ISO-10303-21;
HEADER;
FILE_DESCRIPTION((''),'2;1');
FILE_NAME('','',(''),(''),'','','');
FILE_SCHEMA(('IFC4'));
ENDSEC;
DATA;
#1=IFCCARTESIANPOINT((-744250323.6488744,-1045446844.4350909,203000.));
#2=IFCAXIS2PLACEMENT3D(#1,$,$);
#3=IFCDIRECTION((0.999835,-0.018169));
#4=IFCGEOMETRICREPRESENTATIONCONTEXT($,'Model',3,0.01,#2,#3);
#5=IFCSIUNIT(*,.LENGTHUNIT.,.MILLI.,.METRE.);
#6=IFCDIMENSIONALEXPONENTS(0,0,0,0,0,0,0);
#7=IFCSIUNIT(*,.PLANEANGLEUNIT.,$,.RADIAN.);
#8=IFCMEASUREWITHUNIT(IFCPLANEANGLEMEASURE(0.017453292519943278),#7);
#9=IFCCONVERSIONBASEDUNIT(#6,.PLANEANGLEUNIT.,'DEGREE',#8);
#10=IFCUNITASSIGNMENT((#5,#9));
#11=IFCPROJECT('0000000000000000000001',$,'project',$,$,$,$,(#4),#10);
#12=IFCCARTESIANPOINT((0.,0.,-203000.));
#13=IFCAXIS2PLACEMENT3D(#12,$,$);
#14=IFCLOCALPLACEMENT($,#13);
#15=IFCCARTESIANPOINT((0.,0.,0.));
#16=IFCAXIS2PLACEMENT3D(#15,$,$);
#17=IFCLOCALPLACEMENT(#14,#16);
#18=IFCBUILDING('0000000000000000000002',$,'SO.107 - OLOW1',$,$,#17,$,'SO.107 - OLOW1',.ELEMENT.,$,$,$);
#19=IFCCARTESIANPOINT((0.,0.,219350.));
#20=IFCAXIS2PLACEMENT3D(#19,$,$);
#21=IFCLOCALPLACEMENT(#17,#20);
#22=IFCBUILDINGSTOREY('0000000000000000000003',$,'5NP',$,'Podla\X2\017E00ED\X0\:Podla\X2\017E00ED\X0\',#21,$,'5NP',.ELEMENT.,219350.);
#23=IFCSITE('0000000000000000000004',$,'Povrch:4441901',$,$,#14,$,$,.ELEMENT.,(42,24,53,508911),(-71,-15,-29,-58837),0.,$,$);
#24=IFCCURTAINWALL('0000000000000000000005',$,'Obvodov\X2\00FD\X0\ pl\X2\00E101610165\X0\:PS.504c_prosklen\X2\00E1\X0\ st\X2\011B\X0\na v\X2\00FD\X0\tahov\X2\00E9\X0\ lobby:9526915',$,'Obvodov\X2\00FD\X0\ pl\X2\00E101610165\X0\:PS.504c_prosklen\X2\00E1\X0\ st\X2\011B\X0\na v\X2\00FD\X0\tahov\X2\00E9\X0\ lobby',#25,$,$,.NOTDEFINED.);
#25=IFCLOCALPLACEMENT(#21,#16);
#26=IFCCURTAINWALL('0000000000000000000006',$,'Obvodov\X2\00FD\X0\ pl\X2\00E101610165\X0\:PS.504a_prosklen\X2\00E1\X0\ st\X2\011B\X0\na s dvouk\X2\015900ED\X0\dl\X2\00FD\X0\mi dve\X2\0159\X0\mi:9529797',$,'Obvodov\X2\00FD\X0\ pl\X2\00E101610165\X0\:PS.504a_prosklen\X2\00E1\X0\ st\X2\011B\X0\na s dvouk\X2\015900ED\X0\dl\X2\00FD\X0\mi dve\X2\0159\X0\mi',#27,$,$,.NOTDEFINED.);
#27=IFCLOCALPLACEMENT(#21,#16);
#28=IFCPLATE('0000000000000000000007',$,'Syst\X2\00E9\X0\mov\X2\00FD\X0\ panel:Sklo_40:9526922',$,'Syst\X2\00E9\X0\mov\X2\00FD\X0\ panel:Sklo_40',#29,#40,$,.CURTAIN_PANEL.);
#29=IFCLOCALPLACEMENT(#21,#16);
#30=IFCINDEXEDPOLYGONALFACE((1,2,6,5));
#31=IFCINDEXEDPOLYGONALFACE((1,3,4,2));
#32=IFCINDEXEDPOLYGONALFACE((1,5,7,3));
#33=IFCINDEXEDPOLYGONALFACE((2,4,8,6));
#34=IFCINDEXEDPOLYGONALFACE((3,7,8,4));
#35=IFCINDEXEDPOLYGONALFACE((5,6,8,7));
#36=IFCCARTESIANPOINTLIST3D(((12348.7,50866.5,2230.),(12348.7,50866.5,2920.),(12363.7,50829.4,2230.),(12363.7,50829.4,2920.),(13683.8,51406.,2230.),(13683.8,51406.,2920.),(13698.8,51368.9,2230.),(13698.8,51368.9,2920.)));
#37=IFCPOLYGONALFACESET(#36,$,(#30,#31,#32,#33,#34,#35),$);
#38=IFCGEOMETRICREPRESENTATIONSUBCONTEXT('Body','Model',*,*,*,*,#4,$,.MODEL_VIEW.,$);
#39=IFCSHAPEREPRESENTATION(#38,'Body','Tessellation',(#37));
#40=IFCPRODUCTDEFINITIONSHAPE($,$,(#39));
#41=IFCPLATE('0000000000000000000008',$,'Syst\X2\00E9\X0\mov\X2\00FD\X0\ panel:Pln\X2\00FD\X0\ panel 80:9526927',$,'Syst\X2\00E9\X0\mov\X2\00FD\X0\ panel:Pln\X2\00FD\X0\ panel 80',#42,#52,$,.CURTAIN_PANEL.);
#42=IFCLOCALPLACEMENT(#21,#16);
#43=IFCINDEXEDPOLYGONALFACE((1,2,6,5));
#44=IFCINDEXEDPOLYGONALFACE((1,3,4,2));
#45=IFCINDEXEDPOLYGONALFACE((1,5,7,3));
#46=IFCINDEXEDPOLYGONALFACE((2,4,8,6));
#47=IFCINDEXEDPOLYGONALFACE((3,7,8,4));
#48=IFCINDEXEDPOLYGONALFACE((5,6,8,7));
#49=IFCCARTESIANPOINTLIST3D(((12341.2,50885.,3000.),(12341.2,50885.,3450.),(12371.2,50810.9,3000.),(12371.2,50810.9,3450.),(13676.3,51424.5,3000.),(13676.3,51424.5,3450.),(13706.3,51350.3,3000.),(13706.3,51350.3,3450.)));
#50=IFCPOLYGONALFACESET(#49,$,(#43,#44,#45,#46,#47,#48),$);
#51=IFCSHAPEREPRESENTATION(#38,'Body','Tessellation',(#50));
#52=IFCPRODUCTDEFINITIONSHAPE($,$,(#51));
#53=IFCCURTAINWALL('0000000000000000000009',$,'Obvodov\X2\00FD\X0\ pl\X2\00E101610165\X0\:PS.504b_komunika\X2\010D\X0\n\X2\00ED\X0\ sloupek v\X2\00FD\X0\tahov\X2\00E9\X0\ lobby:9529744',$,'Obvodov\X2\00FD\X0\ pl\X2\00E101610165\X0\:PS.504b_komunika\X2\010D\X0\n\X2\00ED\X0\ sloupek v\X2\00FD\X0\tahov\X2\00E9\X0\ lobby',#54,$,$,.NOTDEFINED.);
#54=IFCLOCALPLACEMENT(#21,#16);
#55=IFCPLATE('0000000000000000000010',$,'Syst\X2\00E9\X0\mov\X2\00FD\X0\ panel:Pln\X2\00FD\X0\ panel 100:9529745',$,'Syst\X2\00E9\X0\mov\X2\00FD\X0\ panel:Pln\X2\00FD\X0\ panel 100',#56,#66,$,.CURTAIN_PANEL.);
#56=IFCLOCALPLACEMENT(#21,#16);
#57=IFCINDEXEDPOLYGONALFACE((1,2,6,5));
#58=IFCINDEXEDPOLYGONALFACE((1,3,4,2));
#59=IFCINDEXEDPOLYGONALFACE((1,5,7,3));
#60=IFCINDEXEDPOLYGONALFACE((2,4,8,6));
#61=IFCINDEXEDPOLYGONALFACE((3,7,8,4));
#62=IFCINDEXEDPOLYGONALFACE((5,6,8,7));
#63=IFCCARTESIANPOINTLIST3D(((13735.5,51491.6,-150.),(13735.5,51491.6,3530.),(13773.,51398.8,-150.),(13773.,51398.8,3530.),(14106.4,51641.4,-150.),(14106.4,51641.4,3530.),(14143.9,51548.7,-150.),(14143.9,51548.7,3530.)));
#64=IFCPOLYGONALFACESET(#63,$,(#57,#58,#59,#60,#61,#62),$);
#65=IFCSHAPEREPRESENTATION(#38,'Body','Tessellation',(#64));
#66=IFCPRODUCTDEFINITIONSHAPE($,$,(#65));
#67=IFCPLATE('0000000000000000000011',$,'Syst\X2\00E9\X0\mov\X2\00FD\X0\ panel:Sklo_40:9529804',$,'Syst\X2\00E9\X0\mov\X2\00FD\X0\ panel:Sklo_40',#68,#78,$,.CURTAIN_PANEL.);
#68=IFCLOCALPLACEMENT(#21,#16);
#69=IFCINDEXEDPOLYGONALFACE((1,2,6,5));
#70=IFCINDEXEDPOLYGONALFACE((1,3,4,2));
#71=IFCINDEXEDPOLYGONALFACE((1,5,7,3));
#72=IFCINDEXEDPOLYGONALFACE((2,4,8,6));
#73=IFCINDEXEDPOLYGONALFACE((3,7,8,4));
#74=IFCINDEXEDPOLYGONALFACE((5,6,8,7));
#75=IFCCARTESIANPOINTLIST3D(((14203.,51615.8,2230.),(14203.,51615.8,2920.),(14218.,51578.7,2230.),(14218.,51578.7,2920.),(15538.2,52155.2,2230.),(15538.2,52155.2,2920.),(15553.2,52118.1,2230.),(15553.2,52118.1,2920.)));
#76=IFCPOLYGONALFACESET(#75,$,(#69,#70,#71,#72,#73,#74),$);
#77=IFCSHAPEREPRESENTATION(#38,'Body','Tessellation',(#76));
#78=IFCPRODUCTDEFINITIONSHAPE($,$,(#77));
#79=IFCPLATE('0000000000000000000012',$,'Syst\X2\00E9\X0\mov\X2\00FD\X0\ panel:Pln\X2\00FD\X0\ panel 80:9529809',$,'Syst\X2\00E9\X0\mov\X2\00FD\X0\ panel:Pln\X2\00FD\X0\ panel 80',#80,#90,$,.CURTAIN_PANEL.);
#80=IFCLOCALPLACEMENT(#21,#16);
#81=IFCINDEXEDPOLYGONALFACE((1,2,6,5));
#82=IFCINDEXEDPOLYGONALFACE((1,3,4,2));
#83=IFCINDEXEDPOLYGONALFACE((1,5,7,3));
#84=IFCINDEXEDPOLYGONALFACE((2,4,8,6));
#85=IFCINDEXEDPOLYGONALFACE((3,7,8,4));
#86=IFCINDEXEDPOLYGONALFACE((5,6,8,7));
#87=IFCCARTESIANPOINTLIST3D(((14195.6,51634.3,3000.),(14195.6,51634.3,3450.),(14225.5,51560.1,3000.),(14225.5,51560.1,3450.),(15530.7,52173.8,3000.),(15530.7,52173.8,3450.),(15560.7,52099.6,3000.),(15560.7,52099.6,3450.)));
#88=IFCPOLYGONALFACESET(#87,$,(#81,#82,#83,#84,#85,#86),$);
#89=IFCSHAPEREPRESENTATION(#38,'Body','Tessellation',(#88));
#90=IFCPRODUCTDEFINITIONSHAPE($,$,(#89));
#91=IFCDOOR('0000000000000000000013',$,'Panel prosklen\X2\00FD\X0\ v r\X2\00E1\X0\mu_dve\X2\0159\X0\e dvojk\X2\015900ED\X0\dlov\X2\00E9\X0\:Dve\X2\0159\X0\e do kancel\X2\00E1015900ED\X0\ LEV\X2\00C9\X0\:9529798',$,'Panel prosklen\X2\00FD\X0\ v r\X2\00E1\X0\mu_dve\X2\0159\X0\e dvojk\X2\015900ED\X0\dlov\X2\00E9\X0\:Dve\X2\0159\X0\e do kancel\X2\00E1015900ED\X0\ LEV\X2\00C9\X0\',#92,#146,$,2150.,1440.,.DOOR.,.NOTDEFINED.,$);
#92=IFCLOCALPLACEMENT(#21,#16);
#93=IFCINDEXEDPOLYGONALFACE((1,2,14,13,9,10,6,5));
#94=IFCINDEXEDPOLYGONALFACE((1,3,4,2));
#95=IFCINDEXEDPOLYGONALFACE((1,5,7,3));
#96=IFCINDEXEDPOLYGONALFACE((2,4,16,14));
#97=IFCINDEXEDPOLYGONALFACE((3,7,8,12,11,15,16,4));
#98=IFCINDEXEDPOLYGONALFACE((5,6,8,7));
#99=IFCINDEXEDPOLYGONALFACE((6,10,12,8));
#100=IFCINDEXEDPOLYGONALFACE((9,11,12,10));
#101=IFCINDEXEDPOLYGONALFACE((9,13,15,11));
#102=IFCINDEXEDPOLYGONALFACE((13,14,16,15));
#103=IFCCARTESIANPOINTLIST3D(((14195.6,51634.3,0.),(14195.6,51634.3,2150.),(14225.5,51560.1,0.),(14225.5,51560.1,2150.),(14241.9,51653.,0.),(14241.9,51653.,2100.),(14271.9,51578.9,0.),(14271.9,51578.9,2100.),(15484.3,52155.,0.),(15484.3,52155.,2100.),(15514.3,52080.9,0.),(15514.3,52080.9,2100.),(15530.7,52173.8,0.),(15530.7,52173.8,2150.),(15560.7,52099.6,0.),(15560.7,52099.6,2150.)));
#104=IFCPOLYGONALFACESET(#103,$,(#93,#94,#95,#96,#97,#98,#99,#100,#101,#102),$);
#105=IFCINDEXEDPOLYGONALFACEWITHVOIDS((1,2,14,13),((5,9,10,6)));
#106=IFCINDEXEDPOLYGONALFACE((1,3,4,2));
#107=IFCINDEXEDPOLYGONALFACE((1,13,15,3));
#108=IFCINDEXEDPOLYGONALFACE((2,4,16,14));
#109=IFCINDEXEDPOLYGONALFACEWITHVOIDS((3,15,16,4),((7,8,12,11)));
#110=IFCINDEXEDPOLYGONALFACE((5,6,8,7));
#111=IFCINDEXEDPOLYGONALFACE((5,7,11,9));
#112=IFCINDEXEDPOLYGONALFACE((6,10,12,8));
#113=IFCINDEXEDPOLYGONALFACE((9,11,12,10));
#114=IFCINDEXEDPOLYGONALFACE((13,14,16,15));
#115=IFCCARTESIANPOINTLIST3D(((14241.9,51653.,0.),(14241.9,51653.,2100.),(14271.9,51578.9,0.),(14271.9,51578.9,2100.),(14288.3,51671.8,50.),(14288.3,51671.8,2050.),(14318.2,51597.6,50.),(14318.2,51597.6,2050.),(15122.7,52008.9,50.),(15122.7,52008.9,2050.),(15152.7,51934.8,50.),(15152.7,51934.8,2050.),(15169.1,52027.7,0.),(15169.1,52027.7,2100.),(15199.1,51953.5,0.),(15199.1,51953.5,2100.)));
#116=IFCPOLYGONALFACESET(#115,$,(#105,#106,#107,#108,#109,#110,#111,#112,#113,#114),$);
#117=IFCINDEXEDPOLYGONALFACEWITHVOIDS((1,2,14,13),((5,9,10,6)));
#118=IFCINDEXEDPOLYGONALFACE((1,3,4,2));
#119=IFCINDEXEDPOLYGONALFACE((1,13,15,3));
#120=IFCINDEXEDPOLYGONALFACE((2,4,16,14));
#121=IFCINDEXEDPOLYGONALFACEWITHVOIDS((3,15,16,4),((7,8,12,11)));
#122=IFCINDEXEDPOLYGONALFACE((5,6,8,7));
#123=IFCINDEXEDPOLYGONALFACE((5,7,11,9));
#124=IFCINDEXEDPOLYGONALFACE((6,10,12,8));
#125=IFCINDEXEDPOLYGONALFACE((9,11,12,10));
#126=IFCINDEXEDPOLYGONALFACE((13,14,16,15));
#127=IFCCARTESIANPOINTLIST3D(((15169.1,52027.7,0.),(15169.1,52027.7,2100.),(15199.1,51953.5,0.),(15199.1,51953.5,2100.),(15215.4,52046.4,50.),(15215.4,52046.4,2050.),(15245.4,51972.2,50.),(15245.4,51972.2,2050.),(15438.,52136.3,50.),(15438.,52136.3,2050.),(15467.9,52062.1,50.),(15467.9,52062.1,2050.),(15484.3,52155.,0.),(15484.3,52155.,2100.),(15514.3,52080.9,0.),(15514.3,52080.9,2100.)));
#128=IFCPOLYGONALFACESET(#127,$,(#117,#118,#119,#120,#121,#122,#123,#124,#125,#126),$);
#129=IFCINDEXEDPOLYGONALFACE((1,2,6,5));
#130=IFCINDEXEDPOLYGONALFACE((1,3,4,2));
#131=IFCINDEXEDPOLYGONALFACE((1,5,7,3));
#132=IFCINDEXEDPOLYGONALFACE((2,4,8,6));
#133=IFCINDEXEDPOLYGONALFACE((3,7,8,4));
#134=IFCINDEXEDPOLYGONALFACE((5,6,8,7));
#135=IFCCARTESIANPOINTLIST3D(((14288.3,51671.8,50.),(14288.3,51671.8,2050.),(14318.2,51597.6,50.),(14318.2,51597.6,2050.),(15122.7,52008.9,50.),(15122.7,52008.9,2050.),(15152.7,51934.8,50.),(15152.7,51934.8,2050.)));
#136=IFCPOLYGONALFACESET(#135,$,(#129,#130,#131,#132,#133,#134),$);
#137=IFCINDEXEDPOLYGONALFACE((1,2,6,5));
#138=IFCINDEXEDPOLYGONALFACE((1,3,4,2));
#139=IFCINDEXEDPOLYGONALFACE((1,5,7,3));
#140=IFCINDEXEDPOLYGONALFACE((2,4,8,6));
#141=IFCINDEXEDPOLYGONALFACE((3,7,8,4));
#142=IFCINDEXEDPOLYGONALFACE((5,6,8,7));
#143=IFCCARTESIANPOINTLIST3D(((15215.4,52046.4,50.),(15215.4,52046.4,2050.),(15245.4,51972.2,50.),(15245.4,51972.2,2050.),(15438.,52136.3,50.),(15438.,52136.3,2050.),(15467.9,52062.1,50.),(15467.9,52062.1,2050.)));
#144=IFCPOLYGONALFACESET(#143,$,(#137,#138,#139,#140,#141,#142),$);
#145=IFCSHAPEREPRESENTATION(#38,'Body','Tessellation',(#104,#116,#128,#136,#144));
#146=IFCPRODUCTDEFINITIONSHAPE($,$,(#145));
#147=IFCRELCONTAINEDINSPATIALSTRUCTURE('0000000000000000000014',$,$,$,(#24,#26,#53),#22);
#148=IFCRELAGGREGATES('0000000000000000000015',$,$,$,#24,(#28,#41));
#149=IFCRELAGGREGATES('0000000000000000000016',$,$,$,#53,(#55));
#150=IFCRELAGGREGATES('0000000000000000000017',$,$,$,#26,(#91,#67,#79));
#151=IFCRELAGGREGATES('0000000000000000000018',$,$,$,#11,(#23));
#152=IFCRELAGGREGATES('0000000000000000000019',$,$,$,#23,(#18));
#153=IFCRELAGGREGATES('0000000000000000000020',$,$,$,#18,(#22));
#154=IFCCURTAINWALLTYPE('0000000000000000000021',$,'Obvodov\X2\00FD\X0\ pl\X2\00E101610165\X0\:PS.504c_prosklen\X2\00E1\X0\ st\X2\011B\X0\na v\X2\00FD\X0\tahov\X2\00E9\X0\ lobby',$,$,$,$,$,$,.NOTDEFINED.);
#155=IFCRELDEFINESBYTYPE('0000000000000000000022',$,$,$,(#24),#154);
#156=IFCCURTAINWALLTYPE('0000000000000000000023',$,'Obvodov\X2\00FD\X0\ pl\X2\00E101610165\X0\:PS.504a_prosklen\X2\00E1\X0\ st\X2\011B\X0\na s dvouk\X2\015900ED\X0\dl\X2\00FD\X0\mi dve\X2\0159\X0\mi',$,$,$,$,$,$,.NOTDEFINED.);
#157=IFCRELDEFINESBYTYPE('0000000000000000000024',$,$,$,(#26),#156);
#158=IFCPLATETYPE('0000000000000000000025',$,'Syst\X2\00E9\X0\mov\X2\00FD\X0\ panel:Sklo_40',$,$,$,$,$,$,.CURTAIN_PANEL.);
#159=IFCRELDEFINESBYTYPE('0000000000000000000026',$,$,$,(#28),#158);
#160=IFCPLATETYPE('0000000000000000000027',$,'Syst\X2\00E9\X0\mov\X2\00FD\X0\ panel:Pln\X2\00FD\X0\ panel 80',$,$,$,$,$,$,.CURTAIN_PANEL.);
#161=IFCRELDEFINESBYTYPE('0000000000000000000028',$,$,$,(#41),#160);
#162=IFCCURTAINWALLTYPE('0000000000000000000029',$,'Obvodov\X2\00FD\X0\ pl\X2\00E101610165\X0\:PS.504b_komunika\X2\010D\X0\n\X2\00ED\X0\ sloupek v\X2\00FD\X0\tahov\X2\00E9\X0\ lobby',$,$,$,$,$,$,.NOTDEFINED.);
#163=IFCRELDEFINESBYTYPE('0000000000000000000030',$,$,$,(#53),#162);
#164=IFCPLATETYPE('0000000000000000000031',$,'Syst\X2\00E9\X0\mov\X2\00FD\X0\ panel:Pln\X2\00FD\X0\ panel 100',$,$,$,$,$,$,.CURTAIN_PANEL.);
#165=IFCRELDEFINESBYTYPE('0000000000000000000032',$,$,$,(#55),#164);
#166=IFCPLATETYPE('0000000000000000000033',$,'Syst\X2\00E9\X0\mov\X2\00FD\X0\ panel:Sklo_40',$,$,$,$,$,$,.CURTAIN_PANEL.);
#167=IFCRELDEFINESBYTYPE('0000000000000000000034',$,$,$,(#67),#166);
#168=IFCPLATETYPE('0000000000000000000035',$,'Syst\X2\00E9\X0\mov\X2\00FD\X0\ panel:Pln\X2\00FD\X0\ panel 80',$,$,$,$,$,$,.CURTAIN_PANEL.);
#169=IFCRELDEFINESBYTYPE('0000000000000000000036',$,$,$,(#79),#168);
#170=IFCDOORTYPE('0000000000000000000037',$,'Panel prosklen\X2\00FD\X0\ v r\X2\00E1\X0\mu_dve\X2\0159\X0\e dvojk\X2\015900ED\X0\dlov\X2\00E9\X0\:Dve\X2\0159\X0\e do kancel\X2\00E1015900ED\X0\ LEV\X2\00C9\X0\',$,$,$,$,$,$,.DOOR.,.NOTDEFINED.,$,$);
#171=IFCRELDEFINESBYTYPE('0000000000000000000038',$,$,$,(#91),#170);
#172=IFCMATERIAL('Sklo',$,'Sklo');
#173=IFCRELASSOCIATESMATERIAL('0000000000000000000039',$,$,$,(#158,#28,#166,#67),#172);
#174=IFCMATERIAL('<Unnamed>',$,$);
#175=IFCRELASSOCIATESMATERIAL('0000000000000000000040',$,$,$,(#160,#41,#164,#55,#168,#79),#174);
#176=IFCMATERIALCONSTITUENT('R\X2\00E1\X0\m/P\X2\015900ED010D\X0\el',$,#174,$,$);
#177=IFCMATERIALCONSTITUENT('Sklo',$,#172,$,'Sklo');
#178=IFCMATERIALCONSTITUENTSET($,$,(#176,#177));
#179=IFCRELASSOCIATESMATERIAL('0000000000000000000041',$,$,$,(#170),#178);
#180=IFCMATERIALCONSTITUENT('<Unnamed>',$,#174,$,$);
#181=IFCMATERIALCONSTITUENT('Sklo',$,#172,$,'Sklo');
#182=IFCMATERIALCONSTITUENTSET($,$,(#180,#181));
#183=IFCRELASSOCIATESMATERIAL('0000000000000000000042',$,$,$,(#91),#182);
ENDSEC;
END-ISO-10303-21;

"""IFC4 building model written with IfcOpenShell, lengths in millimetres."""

from ifc_helpers import new_model, entity, si_unit, converted_unit, direction, frame, origin, place, context, subcontext, project, spatial, indexed_curve, outline, extrude, source, transform, mapped, material, constituent, constituent_set, type_object, type_shapes, element, aggregate, save


model = new_model("IFC4")

# Units and contexts
model_context = context("Model", 3, precision=0.01, world=frame((-744250323.6488744, -1045446844.4350909, 203000.0)), true_north=direction((0.999835, -0.018169)))
body_context = subcontext(model_context, "Body", "Model", "MODEL_VIEW")
ifc_project = project(units=[si_unit("LENGTHUNIT", "METRE", prefix="MILLI"), converted_unit("PLANEANGLEUNIT", "DEGREE", entity("IfcPlaneAngleMeasure", 0.017453292519943278), si_unit("PLANEANGLEUNIT", "RADIAN"), dimensions=[0, 0, 0, 0, 0, 0, 0])], contexts=[model_context])

# Site, building, storey
site_placement = place(None, frame((0.0, 0.0, -203000.0)))
site = spatial("IfcSite", under=ifc_project, at=site_placement, Name="Povrch:4441901", CompositionType="ELEMENT", RefLatitude=(42, 24, 53, 508911), RefLongitude=(-71, -15, -29, -58837), RefElevation=0.0)
building_placement = place(site_placement, origin())
building = spatial("IfcBuilding", under=site, at=building_placement, Name="SO.107 - OLOW1", LongName="SO.107 - OLOW1", CompositionType="ELEMENT")
storey_placement = place(building_placement, frame((0.0, 0.0, 219350.0)))
storey = spatial("IfcBuildingStorey", under=building, at=storey_placement, Name="5NP", ObjectType="Podlaží:Podlaží", LongName="5NP", CompositionType="ELEMENT", Elevation=219350.0)

# Curtain walls
curtain_wall_type_1 = type_object("IfcCurtainWallType", Name="Obvodový plášť:PS.504c_prosklená stěna výtahové lobby", PredefinedType="NOTDEFINED")
curtain_wall_1_placement = place(storey_placement, frame((0.0, 0.0, -219350.0)))
curtain_wall_1 = element("IfcCurtainWall", 1, at=curtain_wall_1_placement, inside=storey, type_object=curtain_wall_type_1, Name="Obvodový plášť:PS.504c_prosklená stěna výtahové lobby:9526915", ObjectType="Obvodový plášť:PS.504c_prosklená stěna výtahové lobby", PredefinedType="NOTDEFINED")
ifc_material_1 = material(Name="<Unnamed>")
curtain_wall_type_2 = type_object("IfcCurtainWallType", Name="Obvodový plášť:PS.504a_prosklená stěna s dvoukřídlými dveřmi", PredefinedType="NOTDEFINED")
curtain_wall_2_placement = place(storey_placement, frame((0.0, 0.0, -219350.0)))
curtain_wall_2 = element("IfcCurtainWall", 2, at=curtain_wall_2_placement, inside=storey, type_object=curtain_wall_type_2, Name="Obvodový plášť:PS.504a_prosklená stěna s dvoukřídlými dveřmi:9529797", ObjectType="Obvodový plášť:PS.504a_prosklená stěna s dvoukřídlými dveřmi", PredefinedType="NOTDEFINED")

# Plates
ifc_material_2 = material(Name="Sklo", Category="Sklo")
plate_type_1 = type_object("IfcPlateType", Name="Systémový panel:Sklo_40", PredefinedType="CURTAIN_PANEL", material=ifc_material_2)
shared_shape_1 = source(origin(), body_context, "Body", "SweptSolid", [
    extrude(outline(indexed_curve([(-20.0, -720.0), (20.0, -720.0), (20.0, 720.0), (-20.0, 720.0), (-20.0, -720.0)], self_intersect=False)), frame((0.0, 0.0, 0.0), z_axis=(0.0, 0.0, 1.0), x_axis=(0.0, 1.0, 0.0)), (0.0, 0.0, 1.0), 690.0),
])
type_shapes(plate_type_1, [shared_shape_1])
plate_1_placement = place(curtain_wall_1_placement, frame((13023.8, 51117.7, 221580.0), z_axis=(0.0, 0.0, 1.0), x_axis=(0.927176, 0.374626, 0.0)))
plate_1 = element("IfcPlate", 3, at=plate_1_placement, type_object=plate_type_1, material=ifc_material_2, Name="Systémový panel:Sklo_40:9526922", ObjectType="Systémový panel:Sklo_40", PredefinedType="CURTAIN_PANEL", context=body_context, shape_type="MappedRepresentation", body=[
    mapped(shared_shape_1, transform((0.0, 0.0, 0.0), scale=1.0)),
])
plate_type_2 = type_object("IfcPlateType", Name="Systémový panel:Plný panel 80", PredefinedType="CURTAIN_PANEL", material=ifc_material_1)
shared_shape_2 = source(origin(), body_context, "Body", "SweptSolid", [
    extrude(outline(indexed_curve([(-40.0, -720.0), (40.0, -720.0), (40.0, 720.0), (-40.0, 720.0), (-40.0, -720.0)], self_intersect=False)), frame((0.0, 0.0, 0.0), z_axis=(0.0, 0.0, 1.0), x_axis=(0.0, 1.0, 0.0)), (0.0, 0.0, 1.0), 450.0),
])
type_shapes(plate_type_2, [shared_shape_2])
plate_2_placement = place(curtain_wall_1_placement, frame((13023.8, 51117.7, 222350.0), z_axis=(0.0, 0.0, 1.0), x_axis=(0.927176, 0.374626, 0.0)))
plate_2 = element("IfcPlate", 4, at=plate_2_placement, type_object=plate_type_2, material=ifc_material_1, Name="Systémový panel:Plný panel 80:9526927", ObjectType="Systémový panel:Plný panel 80", PredefinedType="CURTAIN_PANEL", context=body_context, shape_type="MappedRepresentation", body=[
    mapped(shared_shape_2, transform((0.0, 0.0, 0.0), scale=1.0)),
])
aggregate(curtain_wall_1, [plate_1, plate_2])

# Curtain wall, plate
curtain_wall_type_3 = type_object("IfcCurtainWallType", Name="Obvodový plášť:PS.504b_komunikační sloupek výtahové lobby", PredefinedType="NOTDEFINED")
curtain_wall_3_placement = place(storey_placement, frame((0.0, 0.0, -219350.0)))
curtain_wall_3 = element("IfcCurtainWall", 5, at=curtain_wall_3_placement, inside=storey, type_object=curtain_wall_type_3, Name="Obvodový plášť:PS.504b_komunikační sloupek výtahové lobby:9529744", ObjectType="Obvodový plášť:PS.504b_komunikační sloupek výtahové lobby", PredefinedType="NOTDEFINED")
plate_type_3 = type_object("IfcPlateType", Name="Systémový panel:Plný panel 100", PredefinedType="CURTAIN_PANEL", material=ifc_material_1)
shared_shape_3 = source(origin(), body_context, "Body", "SweptSolid", [
    extrude(outline(indexed_curve([(-50.0, -200.0), (50.0, -200.0), (50.0, 200.0), (-50.0, 200.0), (-50.0, -200.0)], self_intersect=False)), frame((0.0, 50.0, 0.0), z_axis=(0.0, 0.0, 1.0), x_axis=(0.0, 1.0, 0.0)), (0.0, 0.0, 1.0), 3680.0),
])
type_shapes(plate_type_3, [shared_shape_3])
plate_3_placement = place(curtain_wall_3_placement, frame((13958.4, 51473.8, 219200.0), z_axis=(0.0, 0.0, 1.0), x_axis=(0.927176, 0.374626, 0.0)))
plate_3 = element("IfcPlate", 6, at=plate_3_placement, type_object=plate_type_3, material=ifc_material_1, Name="Systémový panel:Plný panel 100:9529745", ObjectType="Systémový panel:Plný panel 100", PredefinedType="CURTAIN_PANEL", context=body_context, shape_type="MappedRepresentation", body=[
    mapped(shared_shape_3, transform((0.0, 0.0, 0.0), scale=1.0)),
])
aggregate(curtain_wall_3, [plate_3])

# Plates
plate_type_4 = type_object("IfcPlateType", Name="Systémový panel:Sklo_40", PredefinedType="CURTAIN_PANEL", material=ifc_material_2)
shared_shape_4 = source(origin(), body_context, "Body", "SweptSolid", [
    extrude(outline(indexed_curve([(-20.0, -720.0), (20.0, -720.0), (20.0, 720.0), (-20.0, 720.0), (-20.0, -720.0)], self_intersect=False)), frame((0.0, 0.0, 0.0), z_axis=(0.0, 0.0, 1.0), x_axis=(0.0, 1.0, 0.0)), (0.0, 0.0, 1.0), 690.0),
])
type_shapes(plate_type_4, [shared_shape_4])
plate_4_placement = place(curtain_wall_2_placement, frame((14878.1, 51866.9, 221580.0), z_axis=(0.0, 0.0, 1.0), x_axis=(-0.927176, -0.374626, 0.0)))
plate_4 = element("IfcPlate", 7, at=plate_4_placement, type_object=plate_type_4, material=ifc_material_2, Name="Systémový panel:Sklo_40:9529804", ObjectType="Systémový panel:Sklo_40", PredefinedType="CURTAIN_PANEL", context=body_context, shape_type="MappedRepresentation", body=[
    mapped(shared_shape_4, transform((0.0, 0.0, 0.0), scale=1.0)),
])
plate_type_5 = type_object("IfcPlateType", Name="Systémový panel:Plný panel 80", PredefinedType="CURTAIN_PANEL", material=ifc_material_1)
shared_shape_5 = source(origin(), body_context, "Body", "SweptSolid", [
    extrude(outline(indexed_curve([(-40.0, -720.0), (40.0, -720.0), (40.0, 720.0), (-40.0, 720.0), (-40.0, -720.0)], self_intersect=False)), frame((0.0, 0.0, 0.0), z_axis=(0.0, 0.0, 1.0), x_axis=(0.0, 1.0, 0.0)), (0.0, 0.0, 1.0), 450.0),
])
type_shapes(plate_type_5, [shared_shape_5])
plate_5_placement = place(curtain_wall_2_placement, frame((14878.1, 51866.9, 222350.0), z_axis=(0.0, 0.0, 1.0), x_axis=(-0.927176, -0.374626, 0.0)))
plate_5 = element("IfcPlate", 8, at=plate_5_placement, type_object=plate_type_5, material=ifc_material_1, Name="Systémový panel:Plný panel 80:9529809", ObjectType="Systémový panel:Plný panel 80", PredefinedType="CURTAIN_PANEL", context=body_context, shape_type="MappedRepresentation", body=[
    mapped(shared_shape_5, transform((0.0, 0.0, 0.0), scale=1.0)),
])

# Door
ifc_constituent_1 = constituent(ifc_material_1, Name="<Unnamed>")
ifc_constituent_2 = constituent(ifc_material_2, Name="Sklo", Category="Sklo")
ifc_constituent_set_1 = constituent_set(constituents=[ifc_constituent_1, ifc_constituent_2])
ifc_constituent_3 = constituent(ifc_material_1, Name="Rám/Příčel")
ifc_constituent_4 = constituent(ifc_material_2, Name="Sklo", Category="Sklo")
ifc_constituent_set_2 = constituent_set(constituents=[ifc_constituent_3, ifc_constituent_4])
door_type = type_object("IfcDoorType", Name="Panel prosklený v rámu_dveře dvojkřídlové:Dveře do kanceláří LEVÉ", OperationType="NOTDEFINED", PredefinedType="DOOR", material=ifc_constituent_set_2)
shared_shape_6 = source(origin(), body_context, "Body", "SweptSolid", [
    extrude(outline(indexed_curve([(-720.0, -1087.5), (720.0, -1087.5), (720.0, 1062.5), (670.0, 1062.5), (670.0, -1037.5), (-670.0, -1037.5), (-670.0, 1062.5), (-720.0, 1062.5), (-720.0, -1087.5)], self_intersect=False)), frame((0.0, 40.0, 1062.5), z_axis=(0.0, -1.0, 0.0), x_axis=(-1.0, 0.0, 0.0)), (0.0, 0.0, 1.0), 80.0),
    extrude(outline(indexed_curve([(-1050.0, -500.0), (1050.0, -500.0), (1050.0, 500.0), (-1050.0, 500.0), (-1050.0, -500.0)], self_intersect=False), holes=[indexed_curve([(-1000.0, -450.0), (-1000.0, 450.0), (1000.0, 450.0), (1000.0, -450.0), (-1000.0, -450.0)], self_intersect=False)]), frame((-170.0, 40.0, 1050.0), z_axis=(0.0, -1.0, 0.0), x_axis=(0.0, 0.0, -1.0)), (0.0, 0.0, 1.0), 80.0),
    extrude(outline(indexed_curve([(-1050.0, -170.0), (1050.0, -170.0), (1050.0, 170.0), (-1050.0, 170.0), (-1050.0, -170.0)], self_intersect=False), holes=[indexed_curve([(-1000.0, -120.0), (-1000.0, 120.0), (1000.0, 120.0), (1000.0, -120.0), (-1000.0, -120.0)], self_intersect=False)]), frame((500.0, 40.0, 1050.0), z_axis=(0.0, -1.0, 0.0), x_axis=(0.0, 0.0, -1.0)), (0.0, 0.0, 1.0), 80.0),
    extrude(outline(indexed_curve([(-450.0, -40.0), (450.0, -40.0), (450.0, 40.0), (-450.0, 40.0), (-450.0, -40.0)], self_intersect=False)), frame((-170.0, 0.0, 50.0)), (0.0, 0.0, 1.0), 2000.0),
    extrude(outline(indexed_curve([(-120.0, -40.0), (120.0, -40.0), (120.0, 40.0), (-120.0, 40.0), (-120.0, -40.0)], self_intersect=False)), frame((500.0, 0.0, 50.0)), (0.0, 0.0, 1.0), 2000.0),
])
type_shapes(door_type, [shared_shape_6])
door_placement = place(curtain_wall_2_placement, frame((14878.1, 51866.9, 219350.0), z_axis=(0.0, 0.0, 1.0), x_axis=(0.927176, 0.374626, 0.0)))
door = element("IfcDoor", 9, at=door_placement, type_object=door_type, material=ifc_constituent_set_1, Name="Panel prosklený v rámu_dveře dvojkřídlové:Dveře do kanceláří LEVÉ:9529798", ObjectType="Panel prosklený v rámu_dveře dvojkřídlové:Dveře do kanceláří LEVÉ", OperationType="NOTDEFINED", OverallHeight=2150.0, OverallWidth=1440.0, PredefinedType="DOOR", context=body_context, shape_type="MappedRepresentation", body=[
    mapped(shared_shape_6, transform((0.0, 0.0, 0.0), scale=1.0)),
])
aggregate(curtain_wall_2, [door, plate_4, plate_5])

save(model, "model.ifc")
